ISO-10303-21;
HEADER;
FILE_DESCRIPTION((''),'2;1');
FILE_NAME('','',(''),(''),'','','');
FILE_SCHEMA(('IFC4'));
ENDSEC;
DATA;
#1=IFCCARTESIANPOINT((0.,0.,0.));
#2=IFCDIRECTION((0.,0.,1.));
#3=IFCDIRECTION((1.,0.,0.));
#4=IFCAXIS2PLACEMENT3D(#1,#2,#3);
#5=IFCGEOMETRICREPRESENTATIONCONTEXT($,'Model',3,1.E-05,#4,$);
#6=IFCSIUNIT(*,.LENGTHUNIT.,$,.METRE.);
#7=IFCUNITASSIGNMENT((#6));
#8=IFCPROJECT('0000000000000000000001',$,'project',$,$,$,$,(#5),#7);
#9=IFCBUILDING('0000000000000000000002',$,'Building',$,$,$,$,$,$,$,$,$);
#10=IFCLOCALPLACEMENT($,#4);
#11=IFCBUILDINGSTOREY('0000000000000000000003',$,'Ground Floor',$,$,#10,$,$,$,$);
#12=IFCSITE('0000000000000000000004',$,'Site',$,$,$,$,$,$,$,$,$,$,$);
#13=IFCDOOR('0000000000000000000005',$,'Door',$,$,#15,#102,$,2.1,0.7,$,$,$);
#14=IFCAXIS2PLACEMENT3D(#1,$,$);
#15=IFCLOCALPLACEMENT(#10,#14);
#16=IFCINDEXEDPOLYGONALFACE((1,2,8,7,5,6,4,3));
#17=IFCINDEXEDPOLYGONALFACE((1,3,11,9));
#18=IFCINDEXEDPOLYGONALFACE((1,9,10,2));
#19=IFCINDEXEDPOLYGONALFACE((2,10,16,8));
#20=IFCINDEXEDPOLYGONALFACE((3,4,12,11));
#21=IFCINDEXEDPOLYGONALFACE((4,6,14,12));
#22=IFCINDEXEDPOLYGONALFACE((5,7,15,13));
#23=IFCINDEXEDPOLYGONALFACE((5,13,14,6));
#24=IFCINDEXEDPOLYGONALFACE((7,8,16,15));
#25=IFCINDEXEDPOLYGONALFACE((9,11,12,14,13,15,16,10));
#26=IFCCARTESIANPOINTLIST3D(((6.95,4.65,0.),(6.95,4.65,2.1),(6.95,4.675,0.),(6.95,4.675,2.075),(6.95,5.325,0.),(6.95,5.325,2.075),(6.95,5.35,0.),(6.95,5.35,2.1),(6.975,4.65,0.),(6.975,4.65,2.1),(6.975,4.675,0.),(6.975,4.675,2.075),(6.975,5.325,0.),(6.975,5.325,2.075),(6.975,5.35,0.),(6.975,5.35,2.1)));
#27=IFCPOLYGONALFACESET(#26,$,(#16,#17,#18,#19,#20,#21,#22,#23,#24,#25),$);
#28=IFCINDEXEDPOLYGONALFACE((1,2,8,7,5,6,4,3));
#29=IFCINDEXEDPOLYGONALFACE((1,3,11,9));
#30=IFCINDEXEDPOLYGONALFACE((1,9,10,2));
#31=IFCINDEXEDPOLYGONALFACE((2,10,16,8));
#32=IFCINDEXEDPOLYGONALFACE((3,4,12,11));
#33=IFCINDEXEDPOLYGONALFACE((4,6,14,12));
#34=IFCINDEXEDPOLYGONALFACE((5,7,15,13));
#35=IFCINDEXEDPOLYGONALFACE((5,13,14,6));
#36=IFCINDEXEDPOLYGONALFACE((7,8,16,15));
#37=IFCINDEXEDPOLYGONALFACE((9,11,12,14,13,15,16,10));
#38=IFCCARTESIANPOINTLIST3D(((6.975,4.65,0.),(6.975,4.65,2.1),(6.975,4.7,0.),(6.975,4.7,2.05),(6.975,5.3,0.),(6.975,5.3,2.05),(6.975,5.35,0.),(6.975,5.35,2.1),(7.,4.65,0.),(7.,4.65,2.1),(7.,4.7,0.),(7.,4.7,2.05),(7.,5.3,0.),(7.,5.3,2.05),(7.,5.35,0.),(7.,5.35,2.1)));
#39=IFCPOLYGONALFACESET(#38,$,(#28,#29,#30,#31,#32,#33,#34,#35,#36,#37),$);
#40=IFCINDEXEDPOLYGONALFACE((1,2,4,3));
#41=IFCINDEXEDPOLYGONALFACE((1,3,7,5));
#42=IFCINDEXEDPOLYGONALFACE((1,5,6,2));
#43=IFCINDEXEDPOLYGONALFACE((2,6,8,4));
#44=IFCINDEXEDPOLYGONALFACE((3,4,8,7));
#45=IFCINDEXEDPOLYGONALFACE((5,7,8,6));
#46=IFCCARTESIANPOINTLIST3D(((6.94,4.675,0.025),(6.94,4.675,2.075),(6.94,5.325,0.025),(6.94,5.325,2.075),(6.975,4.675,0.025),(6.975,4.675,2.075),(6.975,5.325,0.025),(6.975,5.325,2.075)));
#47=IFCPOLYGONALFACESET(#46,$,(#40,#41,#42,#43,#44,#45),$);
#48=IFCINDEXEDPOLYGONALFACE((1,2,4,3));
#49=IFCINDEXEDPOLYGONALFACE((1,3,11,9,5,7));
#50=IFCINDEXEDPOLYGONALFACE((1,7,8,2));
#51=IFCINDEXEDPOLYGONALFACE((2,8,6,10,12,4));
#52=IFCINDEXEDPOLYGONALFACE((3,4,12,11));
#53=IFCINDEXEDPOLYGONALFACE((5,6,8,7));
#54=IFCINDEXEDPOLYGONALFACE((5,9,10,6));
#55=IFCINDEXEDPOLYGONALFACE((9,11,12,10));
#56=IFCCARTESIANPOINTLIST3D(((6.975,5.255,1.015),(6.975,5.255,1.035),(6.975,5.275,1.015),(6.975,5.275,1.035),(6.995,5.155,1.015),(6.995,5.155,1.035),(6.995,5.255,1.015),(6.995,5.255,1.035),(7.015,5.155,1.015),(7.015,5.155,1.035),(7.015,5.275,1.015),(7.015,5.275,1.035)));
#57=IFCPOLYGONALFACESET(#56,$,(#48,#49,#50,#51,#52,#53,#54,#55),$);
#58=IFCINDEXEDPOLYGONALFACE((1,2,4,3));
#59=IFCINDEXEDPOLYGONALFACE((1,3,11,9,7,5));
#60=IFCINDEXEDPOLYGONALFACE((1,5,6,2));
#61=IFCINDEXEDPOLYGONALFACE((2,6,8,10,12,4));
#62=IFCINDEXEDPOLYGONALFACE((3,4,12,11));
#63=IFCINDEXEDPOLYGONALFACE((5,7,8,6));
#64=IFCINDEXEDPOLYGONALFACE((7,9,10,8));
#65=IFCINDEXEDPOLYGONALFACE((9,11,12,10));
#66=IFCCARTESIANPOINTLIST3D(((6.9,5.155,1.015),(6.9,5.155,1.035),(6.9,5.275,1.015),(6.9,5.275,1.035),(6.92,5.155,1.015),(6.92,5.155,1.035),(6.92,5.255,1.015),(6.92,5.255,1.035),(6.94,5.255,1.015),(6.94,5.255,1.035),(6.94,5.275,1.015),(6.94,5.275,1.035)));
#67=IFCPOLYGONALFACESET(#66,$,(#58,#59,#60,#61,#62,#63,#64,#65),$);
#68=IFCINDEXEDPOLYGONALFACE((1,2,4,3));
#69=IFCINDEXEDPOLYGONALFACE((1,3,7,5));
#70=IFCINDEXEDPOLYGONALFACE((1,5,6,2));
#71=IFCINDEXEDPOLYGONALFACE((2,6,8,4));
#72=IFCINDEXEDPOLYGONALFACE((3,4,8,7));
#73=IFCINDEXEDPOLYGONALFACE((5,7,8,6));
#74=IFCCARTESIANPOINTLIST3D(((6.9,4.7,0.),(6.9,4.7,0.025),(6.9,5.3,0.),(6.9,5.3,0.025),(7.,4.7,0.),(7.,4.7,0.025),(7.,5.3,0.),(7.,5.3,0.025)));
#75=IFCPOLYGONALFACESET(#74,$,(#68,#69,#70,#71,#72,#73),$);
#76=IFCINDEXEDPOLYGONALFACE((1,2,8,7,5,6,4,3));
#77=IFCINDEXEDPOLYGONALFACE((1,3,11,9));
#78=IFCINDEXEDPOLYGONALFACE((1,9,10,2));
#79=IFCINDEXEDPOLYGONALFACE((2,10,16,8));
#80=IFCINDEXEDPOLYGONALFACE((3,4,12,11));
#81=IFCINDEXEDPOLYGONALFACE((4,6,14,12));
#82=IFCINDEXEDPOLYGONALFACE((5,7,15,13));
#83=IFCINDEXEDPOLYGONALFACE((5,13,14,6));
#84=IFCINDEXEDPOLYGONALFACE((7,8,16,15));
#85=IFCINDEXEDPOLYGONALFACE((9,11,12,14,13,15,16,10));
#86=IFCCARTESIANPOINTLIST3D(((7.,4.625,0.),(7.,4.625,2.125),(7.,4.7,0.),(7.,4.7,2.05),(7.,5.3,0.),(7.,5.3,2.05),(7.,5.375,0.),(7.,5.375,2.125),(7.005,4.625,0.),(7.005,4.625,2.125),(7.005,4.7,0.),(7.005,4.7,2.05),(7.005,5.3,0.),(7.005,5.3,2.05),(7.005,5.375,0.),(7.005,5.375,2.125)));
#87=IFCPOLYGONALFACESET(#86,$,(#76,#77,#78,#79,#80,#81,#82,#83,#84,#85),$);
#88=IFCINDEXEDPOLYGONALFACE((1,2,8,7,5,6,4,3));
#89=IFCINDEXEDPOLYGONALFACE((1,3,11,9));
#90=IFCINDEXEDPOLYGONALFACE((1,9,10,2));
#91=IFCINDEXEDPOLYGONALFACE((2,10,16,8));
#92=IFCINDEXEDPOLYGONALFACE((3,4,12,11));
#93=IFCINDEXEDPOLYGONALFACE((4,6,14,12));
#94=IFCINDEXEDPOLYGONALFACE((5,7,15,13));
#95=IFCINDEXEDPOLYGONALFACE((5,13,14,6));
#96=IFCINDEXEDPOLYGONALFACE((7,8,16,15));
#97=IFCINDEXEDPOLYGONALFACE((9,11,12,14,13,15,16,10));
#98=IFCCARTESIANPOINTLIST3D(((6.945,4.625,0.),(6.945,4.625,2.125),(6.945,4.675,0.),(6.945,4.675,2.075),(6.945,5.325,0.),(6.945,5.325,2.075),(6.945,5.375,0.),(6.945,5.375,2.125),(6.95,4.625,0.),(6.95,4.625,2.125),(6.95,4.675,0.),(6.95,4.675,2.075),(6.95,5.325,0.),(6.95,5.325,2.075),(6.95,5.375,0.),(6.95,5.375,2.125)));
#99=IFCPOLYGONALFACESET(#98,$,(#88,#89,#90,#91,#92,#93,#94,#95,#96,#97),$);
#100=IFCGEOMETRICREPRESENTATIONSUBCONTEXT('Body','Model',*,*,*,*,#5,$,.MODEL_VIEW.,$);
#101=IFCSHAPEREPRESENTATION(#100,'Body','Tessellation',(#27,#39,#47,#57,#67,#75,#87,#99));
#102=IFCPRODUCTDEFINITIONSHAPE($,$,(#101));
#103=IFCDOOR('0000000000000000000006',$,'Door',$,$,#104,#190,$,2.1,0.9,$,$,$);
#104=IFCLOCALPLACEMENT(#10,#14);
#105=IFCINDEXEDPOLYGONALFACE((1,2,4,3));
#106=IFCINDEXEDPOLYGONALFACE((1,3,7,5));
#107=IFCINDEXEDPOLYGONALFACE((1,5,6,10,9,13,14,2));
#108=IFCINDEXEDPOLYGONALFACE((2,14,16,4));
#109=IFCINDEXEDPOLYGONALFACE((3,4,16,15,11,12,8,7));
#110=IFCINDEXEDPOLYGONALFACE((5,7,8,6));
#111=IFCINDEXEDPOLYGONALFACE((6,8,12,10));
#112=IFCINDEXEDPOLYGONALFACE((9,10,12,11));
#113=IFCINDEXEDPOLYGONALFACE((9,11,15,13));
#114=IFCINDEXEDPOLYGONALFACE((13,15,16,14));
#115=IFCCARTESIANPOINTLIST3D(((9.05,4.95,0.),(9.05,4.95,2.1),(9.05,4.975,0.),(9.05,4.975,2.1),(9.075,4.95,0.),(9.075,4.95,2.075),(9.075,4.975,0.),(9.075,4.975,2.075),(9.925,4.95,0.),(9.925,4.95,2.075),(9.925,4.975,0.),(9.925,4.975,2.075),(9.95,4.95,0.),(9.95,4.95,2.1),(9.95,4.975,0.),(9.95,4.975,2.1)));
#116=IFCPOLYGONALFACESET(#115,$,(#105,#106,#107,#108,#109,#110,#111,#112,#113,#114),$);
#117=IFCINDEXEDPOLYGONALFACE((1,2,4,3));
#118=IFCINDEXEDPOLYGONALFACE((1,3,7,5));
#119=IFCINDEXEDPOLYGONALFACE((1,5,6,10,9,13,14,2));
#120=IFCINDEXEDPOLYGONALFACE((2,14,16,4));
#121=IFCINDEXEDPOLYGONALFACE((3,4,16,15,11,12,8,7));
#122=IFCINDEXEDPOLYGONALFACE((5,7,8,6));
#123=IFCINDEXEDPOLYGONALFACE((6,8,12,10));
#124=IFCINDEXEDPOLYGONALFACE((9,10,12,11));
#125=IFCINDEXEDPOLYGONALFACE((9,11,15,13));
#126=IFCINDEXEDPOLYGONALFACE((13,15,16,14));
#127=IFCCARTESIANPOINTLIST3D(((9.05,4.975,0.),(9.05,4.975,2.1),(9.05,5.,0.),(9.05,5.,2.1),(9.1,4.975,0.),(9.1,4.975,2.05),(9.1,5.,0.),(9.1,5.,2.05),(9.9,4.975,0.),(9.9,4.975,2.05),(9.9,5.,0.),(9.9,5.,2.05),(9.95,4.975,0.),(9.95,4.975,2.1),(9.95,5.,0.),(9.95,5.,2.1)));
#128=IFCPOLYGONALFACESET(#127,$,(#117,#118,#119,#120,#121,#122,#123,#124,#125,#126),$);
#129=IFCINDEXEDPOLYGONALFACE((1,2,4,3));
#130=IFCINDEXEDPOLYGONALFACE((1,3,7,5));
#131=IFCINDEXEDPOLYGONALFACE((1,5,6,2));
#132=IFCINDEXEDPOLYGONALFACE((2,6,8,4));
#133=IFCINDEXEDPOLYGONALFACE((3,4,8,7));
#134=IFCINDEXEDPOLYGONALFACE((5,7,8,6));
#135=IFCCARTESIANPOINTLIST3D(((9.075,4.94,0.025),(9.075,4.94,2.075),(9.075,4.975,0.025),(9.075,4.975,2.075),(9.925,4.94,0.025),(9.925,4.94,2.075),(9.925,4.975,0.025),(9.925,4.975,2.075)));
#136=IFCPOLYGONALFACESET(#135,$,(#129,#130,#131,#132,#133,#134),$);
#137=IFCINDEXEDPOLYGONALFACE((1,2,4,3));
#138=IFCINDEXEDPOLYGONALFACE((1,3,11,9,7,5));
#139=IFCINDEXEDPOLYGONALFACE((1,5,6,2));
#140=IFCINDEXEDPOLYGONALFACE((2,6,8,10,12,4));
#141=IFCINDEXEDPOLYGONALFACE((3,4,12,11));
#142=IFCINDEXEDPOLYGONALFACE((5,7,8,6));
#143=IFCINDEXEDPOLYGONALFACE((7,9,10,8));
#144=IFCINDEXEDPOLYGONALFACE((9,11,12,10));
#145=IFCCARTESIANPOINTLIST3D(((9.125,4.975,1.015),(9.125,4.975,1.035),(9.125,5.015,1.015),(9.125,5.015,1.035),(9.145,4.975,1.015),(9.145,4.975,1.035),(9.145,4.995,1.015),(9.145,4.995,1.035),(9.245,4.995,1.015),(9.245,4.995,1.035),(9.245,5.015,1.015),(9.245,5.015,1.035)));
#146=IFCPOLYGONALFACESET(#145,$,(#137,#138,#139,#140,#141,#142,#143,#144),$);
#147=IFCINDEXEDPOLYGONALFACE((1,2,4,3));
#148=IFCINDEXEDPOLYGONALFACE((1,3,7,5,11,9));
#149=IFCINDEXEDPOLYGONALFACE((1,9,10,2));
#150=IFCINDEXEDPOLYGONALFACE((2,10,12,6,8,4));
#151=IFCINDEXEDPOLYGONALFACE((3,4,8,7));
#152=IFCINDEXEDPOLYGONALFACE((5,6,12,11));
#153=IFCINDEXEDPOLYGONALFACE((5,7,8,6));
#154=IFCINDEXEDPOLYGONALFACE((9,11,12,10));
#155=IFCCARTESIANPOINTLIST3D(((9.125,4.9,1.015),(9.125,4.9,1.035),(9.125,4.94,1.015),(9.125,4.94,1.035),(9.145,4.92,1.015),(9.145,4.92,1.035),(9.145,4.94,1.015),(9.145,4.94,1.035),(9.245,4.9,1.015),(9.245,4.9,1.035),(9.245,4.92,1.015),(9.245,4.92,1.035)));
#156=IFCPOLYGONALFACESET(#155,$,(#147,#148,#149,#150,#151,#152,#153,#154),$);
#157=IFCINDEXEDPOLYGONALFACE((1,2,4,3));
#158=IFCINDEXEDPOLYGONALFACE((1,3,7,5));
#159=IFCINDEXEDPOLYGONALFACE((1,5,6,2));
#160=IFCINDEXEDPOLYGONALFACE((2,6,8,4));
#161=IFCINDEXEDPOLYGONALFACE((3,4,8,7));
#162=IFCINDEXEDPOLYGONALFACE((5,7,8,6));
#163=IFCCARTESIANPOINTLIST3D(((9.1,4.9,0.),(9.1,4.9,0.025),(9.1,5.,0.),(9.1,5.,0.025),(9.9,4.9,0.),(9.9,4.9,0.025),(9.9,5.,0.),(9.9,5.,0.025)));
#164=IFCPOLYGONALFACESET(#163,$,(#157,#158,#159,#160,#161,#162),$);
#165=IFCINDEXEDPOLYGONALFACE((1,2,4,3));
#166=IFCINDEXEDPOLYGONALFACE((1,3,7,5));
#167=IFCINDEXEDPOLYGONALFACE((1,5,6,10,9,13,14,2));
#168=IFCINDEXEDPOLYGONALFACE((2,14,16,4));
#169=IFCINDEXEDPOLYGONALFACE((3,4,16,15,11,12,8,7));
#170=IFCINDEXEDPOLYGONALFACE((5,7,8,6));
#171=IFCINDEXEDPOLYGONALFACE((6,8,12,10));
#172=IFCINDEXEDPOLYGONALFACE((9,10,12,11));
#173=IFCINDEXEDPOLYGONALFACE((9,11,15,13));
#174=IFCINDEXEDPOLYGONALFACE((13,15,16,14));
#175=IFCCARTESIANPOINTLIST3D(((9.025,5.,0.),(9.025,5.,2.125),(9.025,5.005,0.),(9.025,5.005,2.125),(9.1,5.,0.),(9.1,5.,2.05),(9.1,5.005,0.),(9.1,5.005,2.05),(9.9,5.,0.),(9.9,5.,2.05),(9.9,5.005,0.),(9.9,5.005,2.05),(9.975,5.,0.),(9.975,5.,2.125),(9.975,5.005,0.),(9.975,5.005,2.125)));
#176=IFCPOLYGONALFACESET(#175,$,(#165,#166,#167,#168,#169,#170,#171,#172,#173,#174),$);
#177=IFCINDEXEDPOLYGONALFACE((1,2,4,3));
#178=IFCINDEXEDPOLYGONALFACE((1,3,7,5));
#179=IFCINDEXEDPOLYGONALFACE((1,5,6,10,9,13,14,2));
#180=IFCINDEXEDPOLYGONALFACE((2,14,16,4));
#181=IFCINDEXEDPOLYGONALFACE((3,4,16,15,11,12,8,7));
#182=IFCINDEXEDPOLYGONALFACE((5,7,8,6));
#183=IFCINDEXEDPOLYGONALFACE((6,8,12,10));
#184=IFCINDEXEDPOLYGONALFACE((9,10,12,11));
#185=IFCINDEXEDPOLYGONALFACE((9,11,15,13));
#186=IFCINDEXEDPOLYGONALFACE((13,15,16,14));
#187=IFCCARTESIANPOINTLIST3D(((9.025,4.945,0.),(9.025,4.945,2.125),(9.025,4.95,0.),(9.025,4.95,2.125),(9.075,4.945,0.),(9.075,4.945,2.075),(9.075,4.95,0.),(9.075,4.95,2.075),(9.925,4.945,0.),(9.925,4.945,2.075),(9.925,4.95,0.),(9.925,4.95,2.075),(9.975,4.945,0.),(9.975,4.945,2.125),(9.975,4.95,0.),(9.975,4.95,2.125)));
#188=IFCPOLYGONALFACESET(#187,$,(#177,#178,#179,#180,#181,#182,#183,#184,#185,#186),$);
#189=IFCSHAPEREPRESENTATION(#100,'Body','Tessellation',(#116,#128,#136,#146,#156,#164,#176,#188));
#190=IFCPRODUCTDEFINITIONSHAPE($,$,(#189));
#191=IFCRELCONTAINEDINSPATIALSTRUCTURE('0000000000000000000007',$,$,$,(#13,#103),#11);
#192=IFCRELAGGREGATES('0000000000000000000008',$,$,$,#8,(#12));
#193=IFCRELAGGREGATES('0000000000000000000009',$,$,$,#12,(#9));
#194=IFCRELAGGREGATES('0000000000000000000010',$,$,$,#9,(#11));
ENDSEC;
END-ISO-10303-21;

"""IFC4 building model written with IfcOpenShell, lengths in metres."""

from ifc_helpers import new_model, si_unit, frame, origin_with_axes, place, context, subcontext, project, spatial, line, indexed_curve, outline, extrude, element, save


model = new_model("IFC4")

# Units and contexts
model_context = context("Model", 3, precision=1e-05, world=origin_with_axes())
body_context = subcontext(model_context, "Body", "Model", "MODEL_VIEW")
ifc_project = project(units=[si_unit("LENGTHUNIT", "METRE")], contexts=[model_context])

# Site, building, storey
site = spatial("IfcSite", under=ifc_project, Name="Site")
building = spatial("IfcBuilding", under=site, Name="Building")
storey_placement = place(None, origin_with_axes())
storey = spatial("IfcBuildingStorey", under=building, at=storey_placement, Name="Ground Floor")

# Doors
door_1_placement = place(storey_placement, frame((7.0, 4.65, 0.0), z_axis=(0.0, 0.0, 1.0), x_axis=(0.0, 1.0, 0.0)))
element("IfcDoor", 1, at=door_1_placement, inside=storey, Name="Door", OverallHeight=2.1, OverallWidth=0.7, context=body_context, shape_type="SweptSolid", body=[
    extrude(outline(indexed_curve([(0.0, 0.0), (0.0, 2.1), (0.7, 2.1), (0.7, 0.0), (0.675, 0.0), (0.675, 2.075), (0.025, 2.075), (0.025, 0.0)], segments=[line(1, 2, 3, 4, 5, 6, 7, 8, 1)])), frame((0.0, 0.025, 0.0), z_axis=(0.0, -1.0, 0.0), x_axis=(1.0, 0.0, 0.0)), (0.0, 0.0, -1.0), 0.025),
    extrude(outline(indexed_curve([(0.0, 0.0), (0.0, 2.1), (0.7, 2.1), (0.7, 0.0), (0.65, 0.0), (0.65, 2.05), (0.05, 2.05), (0.05, 0.0)], segments=[line(1, 2, 3, 4, 5, 6, 7, 8, 1)])), frame((0.0, 0.0, 0.0), z_axis=(0.0, -1.0, 0.0), x_axis=(1.0, 0.0, 0.0)), (0.0, 0.0, -1.0), 0.025),
    extrude(outline(indexed_curve([(0.0, 0.0), (0.65, 0.0), (0.65, 0.035), (0.0, 0.035)], segments=[line(1, 2, 3, 4, 1)])), frame((0.025, 0.025, 0.025), z_axis=(0.0, 0.0, 1.0), x_axis=(1.0, 0.0, 0.0)), (0.0, 0.0, 1.0), 2.05),
    extrude(outline(indexed_curve([(0.0, 0.0), (0.0, -0.04), (-0.12, -0.04), (-0.12, -0.02), (-0.02, -0.02), (-0.02, 0.0)], segments=[line(1, 2, 3, 4, 5, 6, 1)])), frame((0.625, 0.025, 1.015), z_axis=(0.0, 0.0, 1.0), x_axis=(1.0, 0.0, 0.0)), (0.0, 0.0, 1.0), 0.02),
    extrude(outline(indexed_curve([(0.0, 0.0), (0.0, 0.04), (-0.12, 0.04), (-0.12, 0.02), (-0.02, 0.02), (-0.02, 0.0)], segments=[line(1, 2, 3, 4, 5, 6, 1)])), frame((0.625, 0.06, 1.015), z_axis=(0.0, 0.0, 1.0), x_axis=(1.0, 0.0, 0.0)), (0.0, 0.0, 1.0), 0.02),
    extrude(outline(indexed_curve([(0.0, 0.0), (0.6, 0.0), (0.6, 0.1), (0.0, 0.1)], segments=[line(1, 2, 3, 4, 1)])), frame((0.05, 0.0, 0.0), z_axis=(0.0, 0.0, 1.0), x_axis=(1.0, 0.0, 0.0)), (0.0, 0.0, 1.0), 0.025),
    extrude(outline(indexed_curve([(0.0, 0.0), (0.0, 2.125), (0.75, 2.125), (0.75, 0.0), (0.675, 0.0), (0.675, 2.05), (0.075, 2.05), (0.075, 0.0)], segments=[line(1, 2, 3, 4, 5, 6, 7, 8, 1)])), frame((-0.025, -0.005, 0.0), z_axis=(0.0, -1.0, 0.0), x_axis=(1.0, 0.0, 0.0)), (0.0, 0.0, -1.0), 0.005),
    extrude(outline(indexed_curve([(0.0, 0.0), (0.0, 2.125), (0.75, 2.125), (0.75, 0.0), (0.7, 0.0), (0.7, 2.075), (0.05, 2.075), (0.05, 0.0)], segments=[line(1, 2, 3, 4, 5, 6, 7, 8, 1)])), frame((-0.025, 0.05, 0.0), z_axis=(0.0, -1.0, 0.0), x_axis=(1.0, 0.0, 0.0)), (0.0, 0.0, -1.0), 0.005),
])
door_2_placement = place(storey_placement, frame((9.95, 5.0, 0.0), z_axis=(0.0, 0.0, 1.0), x_axis=(-1.0, 0.0, 0.0)))
element("IfcDoor", 2, at=door_2_placement, inside=storey, Name="Door", OverallHeight=2.1, OverallWidth=0.9, context=body_context, shape_type="SweptSolid", body=[
    extrude(outline(indexed_curve([(0.0, 0.0), (0.0, 2.1), (0.9, 2.1), (0.9, 0.0), (0.875, 0.0), (0.875, 2.075), (0.025, 2.075), (0.025, 0.0)], segments=[line(1, 2, 3, 4, 5, 6, 7, 8, 1)])), frame((0.0, 0.025, 0.0), z_axis=(0.0, -1.0, 0.0), x_axis=(1.0, 0.0, 0.0)), (0.0, 0.0, -1.0), 0.025),
    extrude(outline(indexed_curve([(0.0, 0.0), (0.0, 2.1), (0.9, 2.1), (0.9, 0.0), (0.85, 0.0), (0.85, 2.05), (0.05, 2.05), (0.05, 0.0)], segments=[line(1, 2, 3, 4, 5, 6, 7, 8, 1)])), frame((0.0, 0.0, 0.0), z_axis=(0.0, -1.0, 0.0), x_axis=(1.0, 0.0, 0.0)), (0.0, 0.0, -1.0), 0.025),
    extrude(outline(indexed_curve([(0.0, 0.0), (0.85, 0.0), (0.85, 0.035), (0.0, 0.035)], segments=[line(1, 2, 3, 4, 1)])), frame((0.025, 0.025, 0.025), z_axis=(0.0, 0.0, 1.0), x_axis=(1.0, 0.0, 0.0)), (0.0, 0.0, 1.0), 2.05),
    extrude(outline(indexed_curve([(0.0, 0.0), (0.0, -0.04), (-0.12, -0.04), (-0.12, -0.02), (-0.02, -0.02), (-0.02, 0.0)], segments=[line(1, 2, 3, 4, 5, 6, 1)])), frame((0.825, 0.025, 1.015), z_axis=(0.0, 0.0, 1.0), x_axis=(1.0, 0.0, 0.0)), (0.0, 0.0, 1.0), 0.02),
    extrude(outline(indexed_curve([(0.0, 0.0), (0.0, 0.04), (-0.12, 0.04), (-0.12, 0.02), (-0.02, 0.02), (-0.02, 0.0)], segments=[line(1, 2, 3, 4, 5, 6, 1)])), frame((0.825, 0.06, 1.015), z_axis=(0.0, 0.0, 1.0), x_axis=(1.0, 0.0, 0.0)), (0.0, 0.0, 1.0), 0.02),
    extrude(outline(indexed_curve([(0.0, 0.0), (0.8, 0.0), (0.8, 0.1), (0.0, 0.1)], segments=[line(1, 2, 3, 4, 1)])), frame((0.05, 0.0, 0.0), z_axis=(0.0, 0.0, 1.0), x_axis=(1.0, 0.0, 0.0)), (0.0, 0.0, 1.0), 0.025),
    extrude(outline(indexed_curve([(0.0, 0.0), (0.0, 2.125), (0.95, 2.125), (0.95, 0.0), (0.875, 0.0), (0.875, 2.05), (0.075, 2.05), (0.075, 0.0)], segments=[line(1, 2, 3, 4, 5, 6, 7, 8, 1)])), frame((-0.025, -0.005, 0.0), z_axis=(0.0, -1.0, 0.0), x_axis=(1.0, 0.0, 0.0)), (0.0, 0.0, -1.0), 0.005),
    extrude(outline(indexed_curve([(0.0, 0.0), (0.0, 2.125), (0.95, 2.125), (0.95, 0.0), (0.9, 0.0), (0.9, 2.075), (0.05, 2.075), (0.05, 0.0)], segments=[line(1, 2, 3, 4, 5, 6, 7, 8, 1)])), frame((-0.025, 0.05, 0.0), z_axis=(0.0, -1.0, 0.0), x_axis=(1.0, 0.0, 0.0)), (0.0, 0.0, -1.0), 0.005),
])

save(model, "model.ifc")
